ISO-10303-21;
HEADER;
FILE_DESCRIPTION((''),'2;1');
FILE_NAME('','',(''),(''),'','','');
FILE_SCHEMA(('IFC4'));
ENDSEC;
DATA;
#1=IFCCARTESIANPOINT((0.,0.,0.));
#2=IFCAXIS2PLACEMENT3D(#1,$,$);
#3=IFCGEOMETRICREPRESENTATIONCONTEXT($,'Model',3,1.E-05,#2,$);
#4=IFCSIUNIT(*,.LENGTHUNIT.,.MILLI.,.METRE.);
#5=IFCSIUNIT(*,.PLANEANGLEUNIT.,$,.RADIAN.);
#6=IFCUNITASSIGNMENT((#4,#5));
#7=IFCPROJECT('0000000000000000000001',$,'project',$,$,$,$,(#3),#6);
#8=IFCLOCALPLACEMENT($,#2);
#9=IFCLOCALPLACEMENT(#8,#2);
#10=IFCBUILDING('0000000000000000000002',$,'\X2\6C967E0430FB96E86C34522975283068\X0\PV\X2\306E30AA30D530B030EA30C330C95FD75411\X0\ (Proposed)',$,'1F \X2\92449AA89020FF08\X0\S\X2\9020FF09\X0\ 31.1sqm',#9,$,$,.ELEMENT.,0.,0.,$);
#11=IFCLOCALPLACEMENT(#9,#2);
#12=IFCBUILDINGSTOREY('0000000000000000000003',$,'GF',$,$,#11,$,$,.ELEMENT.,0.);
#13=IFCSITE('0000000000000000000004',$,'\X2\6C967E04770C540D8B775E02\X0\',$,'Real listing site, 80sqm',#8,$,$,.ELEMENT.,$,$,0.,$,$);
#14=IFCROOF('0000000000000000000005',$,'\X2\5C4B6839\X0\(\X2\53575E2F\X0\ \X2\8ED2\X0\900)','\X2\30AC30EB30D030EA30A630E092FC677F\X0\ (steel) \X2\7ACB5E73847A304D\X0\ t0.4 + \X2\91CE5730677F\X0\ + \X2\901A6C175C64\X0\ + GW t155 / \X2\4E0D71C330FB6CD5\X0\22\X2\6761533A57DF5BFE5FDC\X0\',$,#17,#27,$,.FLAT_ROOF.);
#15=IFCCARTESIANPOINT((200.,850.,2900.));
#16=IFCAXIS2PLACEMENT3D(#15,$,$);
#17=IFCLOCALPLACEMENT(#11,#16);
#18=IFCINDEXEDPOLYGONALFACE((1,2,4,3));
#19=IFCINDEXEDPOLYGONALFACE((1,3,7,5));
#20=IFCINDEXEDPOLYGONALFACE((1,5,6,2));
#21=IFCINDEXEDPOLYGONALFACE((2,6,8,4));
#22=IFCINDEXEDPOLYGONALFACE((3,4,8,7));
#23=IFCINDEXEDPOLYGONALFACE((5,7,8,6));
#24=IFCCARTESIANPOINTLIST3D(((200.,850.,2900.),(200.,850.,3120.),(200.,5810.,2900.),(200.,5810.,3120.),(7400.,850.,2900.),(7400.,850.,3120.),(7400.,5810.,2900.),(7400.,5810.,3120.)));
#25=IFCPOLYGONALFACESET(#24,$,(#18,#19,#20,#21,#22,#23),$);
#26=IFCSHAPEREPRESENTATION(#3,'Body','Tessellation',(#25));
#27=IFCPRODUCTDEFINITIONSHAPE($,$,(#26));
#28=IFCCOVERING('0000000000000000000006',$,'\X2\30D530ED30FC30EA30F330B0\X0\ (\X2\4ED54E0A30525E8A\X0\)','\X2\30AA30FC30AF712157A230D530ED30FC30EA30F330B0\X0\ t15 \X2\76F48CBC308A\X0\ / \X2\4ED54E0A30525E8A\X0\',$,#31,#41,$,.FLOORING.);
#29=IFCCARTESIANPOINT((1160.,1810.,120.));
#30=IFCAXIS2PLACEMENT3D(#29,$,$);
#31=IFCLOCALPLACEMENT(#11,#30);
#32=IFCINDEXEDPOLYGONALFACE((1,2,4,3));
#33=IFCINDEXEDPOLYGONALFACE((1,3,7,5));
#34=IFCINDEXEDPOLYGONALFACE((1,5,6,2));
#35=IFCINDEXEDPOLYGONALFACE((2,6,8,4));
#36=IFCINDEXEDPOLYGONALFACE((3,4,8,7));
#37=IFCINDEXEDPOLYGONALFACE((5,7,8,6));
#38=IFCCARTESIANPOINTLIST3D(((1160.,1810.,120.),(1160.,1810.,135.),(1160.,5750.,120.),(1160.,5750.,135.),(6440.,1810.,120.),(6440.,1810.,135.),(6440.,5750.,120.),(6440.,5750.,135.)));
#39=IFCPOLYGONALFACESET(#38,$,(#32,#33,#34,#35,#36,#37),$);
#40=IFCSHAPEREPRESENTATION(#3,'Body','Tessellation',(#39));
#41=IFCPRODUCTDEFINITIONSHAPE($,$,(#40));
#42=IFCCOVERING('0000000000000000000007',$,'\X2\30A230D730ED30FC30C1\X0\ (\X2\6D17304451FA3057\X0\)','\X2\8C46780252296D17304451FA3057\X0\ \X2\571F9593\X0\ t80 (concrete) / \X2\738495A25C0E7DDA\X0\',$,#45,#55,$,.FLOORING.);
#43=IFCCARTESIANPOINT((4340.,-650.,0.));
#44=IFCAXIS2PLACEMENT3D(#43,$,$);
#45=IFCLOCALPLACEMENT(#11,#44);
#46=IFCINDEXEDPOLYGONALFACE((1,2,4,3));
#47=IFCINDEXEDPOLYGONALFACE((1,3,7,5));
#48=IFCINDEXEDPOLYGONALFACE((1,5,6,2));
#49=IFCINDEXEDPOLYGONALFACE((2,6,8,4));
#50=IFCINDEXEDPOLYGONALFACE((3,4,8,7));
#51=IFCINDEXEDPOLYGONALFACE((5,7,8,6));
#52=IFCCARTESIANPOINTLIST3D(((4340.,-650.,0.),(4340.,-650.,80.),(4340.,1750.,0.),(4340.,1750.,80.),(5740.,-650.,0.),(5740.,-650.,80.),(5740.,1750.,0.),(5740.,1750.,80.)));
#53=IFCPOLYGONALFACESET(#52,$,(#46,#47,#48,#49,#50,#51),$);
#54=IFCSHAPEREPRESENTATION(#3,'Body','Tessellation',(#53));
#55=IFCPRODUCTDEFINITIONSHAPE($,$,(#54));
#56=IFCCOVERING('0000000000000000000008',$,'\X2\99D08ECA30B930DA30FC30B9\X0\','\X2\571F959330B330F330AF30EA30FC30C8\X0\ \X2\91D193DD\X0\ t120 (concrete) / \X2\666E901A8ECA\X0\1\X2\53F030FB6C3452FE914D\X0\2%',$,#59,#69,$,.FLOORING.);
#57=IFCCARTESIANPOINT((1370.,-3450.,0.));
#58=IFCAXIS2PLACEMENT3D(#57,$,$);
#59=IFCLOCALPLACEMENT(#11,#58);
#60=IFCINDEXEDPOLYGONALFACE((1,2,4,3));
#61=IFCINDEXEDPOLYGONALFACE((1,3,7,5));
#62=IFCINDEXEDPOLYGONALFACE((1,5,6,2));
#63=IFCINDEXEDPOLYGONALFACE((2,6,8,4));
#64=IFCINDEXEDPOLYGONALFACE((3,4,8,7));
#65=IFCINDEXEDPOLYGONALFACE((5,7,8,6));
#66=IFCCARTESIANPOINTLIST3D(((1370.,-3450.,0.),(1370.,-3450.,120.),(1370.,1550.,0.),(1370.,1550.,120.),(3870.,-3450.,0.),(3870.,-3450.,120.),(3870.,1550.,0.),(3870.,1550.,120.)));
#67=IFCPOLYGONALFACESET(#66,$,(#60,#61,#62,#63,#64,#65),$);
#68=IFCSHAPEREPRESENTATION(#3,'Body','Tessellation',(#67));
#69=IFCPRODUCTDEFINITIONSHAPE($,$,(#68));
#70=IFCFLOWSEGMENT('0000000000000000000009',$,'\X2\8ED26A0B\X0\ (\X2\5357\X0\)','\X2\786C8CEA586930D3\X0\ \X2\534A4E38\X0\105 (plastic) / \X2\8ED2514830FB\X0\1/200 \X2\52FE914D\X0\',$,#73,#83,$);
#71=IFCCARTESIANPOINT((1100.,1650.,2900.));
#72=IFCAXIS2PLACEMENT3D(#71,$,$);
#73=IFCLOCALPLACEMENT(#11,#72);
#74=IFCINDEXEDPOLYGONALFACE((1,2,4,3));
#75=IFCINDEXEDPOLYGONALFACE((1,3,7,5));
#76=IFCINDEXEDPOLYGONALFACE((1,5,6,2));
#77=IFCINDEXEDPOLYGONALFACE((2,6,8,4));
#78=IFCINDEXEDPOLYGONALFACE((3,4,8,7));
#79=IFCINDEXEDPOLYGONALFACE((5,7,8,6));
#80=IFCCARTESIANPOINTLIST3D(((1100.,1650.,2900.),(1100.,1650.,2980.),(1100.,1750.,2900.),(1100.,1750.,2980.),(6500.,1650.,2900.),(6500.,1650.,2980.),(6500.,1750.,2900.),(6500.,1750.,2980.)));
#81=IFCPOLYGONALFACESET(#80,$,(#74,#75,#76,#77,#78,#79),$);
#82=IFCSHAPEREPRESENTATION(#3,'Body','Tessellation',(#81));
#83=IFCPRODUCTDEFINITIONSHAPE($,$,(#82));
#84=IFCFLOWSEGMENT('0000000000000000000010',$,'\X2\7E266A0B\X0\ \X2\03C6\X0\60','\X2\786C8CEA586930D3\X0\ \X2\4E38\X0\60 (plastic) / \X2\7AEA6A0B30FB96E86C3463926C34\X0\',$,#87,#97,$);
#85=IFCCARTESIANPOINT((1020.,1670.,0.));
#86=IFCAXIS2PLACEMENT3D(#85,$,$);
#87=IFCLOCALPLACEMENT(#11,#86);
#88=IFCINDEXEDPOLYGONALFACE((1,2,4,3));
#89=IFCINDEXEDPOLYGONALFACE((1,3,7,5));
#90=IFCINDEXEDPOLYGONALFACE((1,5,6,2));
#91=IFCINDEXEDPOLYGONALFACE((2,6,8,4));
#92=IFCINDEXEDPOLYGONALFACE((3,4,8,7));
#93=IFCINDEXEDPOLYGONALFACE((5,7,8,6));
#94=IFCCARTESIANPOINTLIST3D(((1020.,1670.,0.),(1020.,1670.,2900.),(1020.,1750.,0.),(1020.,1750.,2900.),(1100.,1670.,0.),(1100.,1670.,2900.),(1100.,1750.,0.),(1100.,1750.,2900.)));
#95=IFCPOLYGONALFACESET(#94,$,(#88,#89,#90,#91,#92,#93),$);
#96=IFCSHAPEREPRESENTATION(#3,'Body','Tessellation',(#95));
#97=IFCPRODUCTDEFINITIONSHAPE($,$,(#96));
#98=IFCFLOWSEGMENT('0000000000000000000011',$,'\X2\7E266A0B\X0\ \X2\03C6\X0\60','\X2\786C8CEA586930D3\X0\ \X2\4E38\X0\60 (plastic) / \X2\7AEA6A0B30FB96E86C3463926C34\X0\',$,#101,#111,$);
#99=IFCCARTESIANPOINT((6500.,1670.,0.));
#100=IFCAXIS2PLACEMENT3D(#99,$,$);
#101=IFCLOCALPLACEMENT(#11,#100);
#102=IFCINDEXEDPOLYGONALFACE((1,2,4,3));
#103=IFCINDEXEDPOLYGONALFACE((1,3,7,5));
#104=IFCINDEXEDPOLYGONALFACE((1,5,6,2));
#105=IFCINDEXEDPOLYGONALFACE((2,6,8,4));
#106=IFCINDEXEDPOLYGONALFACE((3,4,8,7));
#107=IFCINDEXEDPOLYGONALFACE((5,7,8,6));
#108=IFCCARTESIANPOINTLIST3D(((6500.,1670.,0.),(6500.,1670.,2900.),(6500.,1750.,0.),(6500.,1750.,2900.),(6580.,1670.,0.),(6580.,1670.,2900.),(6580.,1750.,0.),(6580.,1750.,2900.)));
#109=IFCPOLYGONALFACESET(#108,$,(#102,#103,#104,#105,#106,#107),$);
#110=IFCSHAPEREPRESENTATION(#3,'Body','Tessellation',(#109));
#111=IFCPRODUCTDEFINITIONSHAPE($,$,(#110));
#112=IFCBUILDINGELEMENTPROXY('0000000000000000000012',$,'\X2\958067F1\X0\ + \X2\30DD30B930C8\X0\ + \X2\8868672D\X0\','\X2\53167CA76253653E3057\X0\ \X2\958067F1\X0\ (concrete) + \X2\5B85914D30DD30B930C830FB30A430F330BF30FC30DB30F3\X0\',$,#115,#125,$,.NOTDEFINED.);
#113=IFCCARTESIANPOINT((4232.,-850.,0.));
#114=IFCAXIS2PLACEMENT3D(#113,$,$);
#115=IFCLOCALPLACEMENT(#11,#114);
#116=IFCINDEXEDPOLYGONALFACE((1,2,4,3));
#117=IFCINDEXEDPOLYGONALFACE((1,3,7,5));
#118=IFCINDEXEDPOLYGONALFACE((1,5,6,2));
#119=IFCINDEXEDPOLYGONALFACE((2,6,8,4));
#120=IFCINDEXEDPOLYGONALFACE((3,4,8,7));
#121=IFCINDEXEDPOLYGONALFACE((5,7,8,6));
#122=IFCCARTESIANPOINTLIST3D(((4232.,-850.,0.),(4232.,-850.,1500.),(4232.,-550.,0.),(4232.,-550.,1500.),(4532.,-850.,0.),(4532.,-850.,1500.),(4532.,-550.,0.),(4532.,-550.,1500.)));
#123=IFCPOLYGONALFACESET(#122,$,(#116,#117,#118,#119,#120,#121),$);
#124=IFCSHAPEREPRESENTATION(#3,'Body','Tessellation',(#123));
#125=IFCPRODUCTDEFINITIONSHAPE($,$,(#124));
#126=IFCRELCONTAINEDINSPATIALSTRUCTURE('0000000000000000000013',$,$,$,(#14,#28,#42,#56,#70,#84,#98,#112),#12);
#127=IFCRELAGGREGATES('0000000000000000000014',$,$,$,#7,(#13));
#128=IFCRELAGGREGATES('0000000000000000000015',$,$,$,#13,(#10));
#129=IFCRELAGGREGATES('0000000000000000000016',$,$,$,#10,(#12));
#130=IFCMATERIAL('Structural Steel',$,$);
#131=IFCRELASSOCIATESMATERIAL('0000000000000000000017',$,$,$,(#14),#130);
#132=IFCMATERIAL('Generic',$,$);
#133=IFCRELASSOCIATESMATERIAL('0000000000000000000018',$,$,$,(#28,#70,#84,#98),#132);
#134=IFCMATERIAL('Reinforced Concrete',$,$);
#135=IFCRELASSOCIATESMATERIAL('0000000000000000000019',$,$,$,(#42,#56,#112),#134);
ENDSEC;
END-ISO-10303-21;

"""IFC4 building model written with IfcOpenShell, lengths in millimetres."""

from ifc_helpers import new_model, si_unit, frame, frame_2d, origin, place, context, project, spatial, rectangle, extrude, material, element, save


model = new_model("IFC4")

# Units and contexts
model_context = context("Model", 3, precision=1e-05, world=origin())
ifc_project = project(units=[si_unit("LENGTHUNIT", "METRE", prefix="MILLI"), si_unit("PLANEANGLEUNIT", "RADIAN")], contexts=[model_context])

# Site, building, storey
site_placement = place(None, origin())
site = spatial("IfcSite", under=ifc_project, at=site_placement, Name="沖縄県名護市", ObjectType="Real listing site, 80sqm", CompositionType="ELEMENT", RefElevation=0.0)
building_placement = place(site_placement, origin())
building = spatial("IfcBuilding", under=site, at=building_placement, Name="沖縄・雨水利用とPVのオフグリッド志向 (Proposed)", ObjectType="1F 鉄骨造（S造） 31.1sqm", CompositionType="ELEMENT", ElevationOfRefHeight=0.0, ElevationOfTerrain=0.0)
storey_placement = place(building_placement, origin())
storey = spatial("IfcBuildingStorey", under=building, at=storey_placement, Name="GF", CompositionType="ELEMENT", Elevation=0.0)

# Shared definitions
ifc_material_1 = material(Name="Reinforced Concrete")

# Roof
ifc_material_2 = material(Name="Structural Steel")
roof_placement = place(storey_placement, frame((200.0, 850.0, 2900.0)))
element("IfcRoof", 1, at=roof_placement, inside=storey, material=ifc_material_2, Name="屋根(南帯 軒900)", Description="ガルバリウム鋼板 (steel) 立平葺き t0.4 + 野地板 + 通気層 + GW t155 / 不燃・法22条区域対応", PredefinedType="FLAT_ROOF", context=model_context, shape_type="SweptSolid", body=[
    extrude(rectangle(XDim=7200.0, YDim=4960.0, at=frame_2d((3600.0, 2480.0))), frame((200.0, 850.0, 2900.0)), (0.0, 0.0, 1.0), 220.0),
])

# Coverings
ifc_material_3 = material(Name="Generic")
covering_1_placement = place(storey_placement, frame((1160.0, 1810.0, 120.0)))
element("IfcCovering", 2, at=covering_1_placement, inside=storey, material=ifc_material_3, Name="フローリング (仕上げ床)", Description="オーク無垢フローリング t15 直貼り / 仕上げ床", PredefinedType="FLOORING", context=model_context, shape_type="SweptSolid", body=[
    extrude(rectangle(XDim=5280.0, YDim=3940.0, at=frame_2d((2640.0, 1970.0))), frame((1160.0, 1810.0, 120.0)), (0.0, 0.0, 1.0), 15.0),
])
covering_2_placement = place(storey_placement, frame((4340.0, -650.0, 0.0)))
element("IfcCovering", 3, at=covering_2_placement, inside=storey, material=ifc_material_1, Name="アプローチ (洗い出し)", Description="豆砂利洗い出し 土間 t80 (concrete) / 玄関導線", PredefinedType="FLOORING", context=model_context, shape_type="SweptSolid", body=[
    extrude(rectangle(XDim=1400.0, YDim=2400.0, at=frame_2d((700.0, 1200.0))), frame((4340.0, -650.0, 0.0)), (0.0, 0.0, 1.0), 80.0),
])
covering_3_placement = place(storey_placement, frame((1370.0, -3450.0, 0.0)))
element("IfcCovering", 4, at=covering_3_placement, inside=storey, material=ifc_material_1, Name="駐車スペース", Description="土間コンクリート 金鏝 t120 (concrete) / 普通車1台・水勾配2%", PredefinedType="FLOORING", context=model_context, shape_type="SweptSolid", body=[
    extrude(rectangle(XDim=2500.0, YDim=5000.0, at=frame_2d((1250.0, 2500.0))), frame((1370.0, -3450.0, 0.0)), (0.0, 0.0, 1.0), 120.0),
])

# Flow segments
flow_segment_1_placement = place(storey_placement, frame((1100.0, 1650.0, 2900.0)))
element("IfcFlowSegment", 5, at=flow_segment_1_placement, inside=storey, material=ifc_material_3, Name="軒樋 (南)", Description="硬質塩ビ 半丸105 (plastic) / 軒先・1/200 勾配", context=model_context, shape_type="SweptSolid", body=[
    extrude(rectangle(XDim=5400.0, YDim=100.0, at=frame_2d((2700.0, 50.0))), frame((1100.0, 1650.0, 2900.0)), (0.0, 0.0, 1.0), 80.0),
])
flow_segment_2_placement = place(storey_placement, frame((1020.0, 1670.0, 0.0)))
element("IfcFlowSegment", 6, at=flow_segment_2_placement, inside=storey, material=ifc_material_3, Name="縦樋 φ60", Description="硬質塩ビ 丸60 (plastic) / 竪樋・雨水排水", context=model_context, shape_type="SweptSolid", body=[
    extrude(rectangle(XDim=80.0, YDim=80.0, at=frame_2d((40.0, 40.0))), frame((1020.0, 1670.0, 0.0)), (0.0, 0.0, 1.0), 2900.0),
])
flow_segment_3_placement = place(storey_placement, frame((6500.0, 1670.0, 0.0)))
element("IfcFlowSegment", 7, at=flow_segment_3_placement, inside=storey, material=ifc_material_3, Name="縦樋 φ60", Description="硬質塩ビ 丸60 (plastic) / 竪樋・雨水排水", context=model_context, shape_type="SweptSolid", body=[
    extrude(rectangle(XDim=80.0, YDim=80.0, at=frame_2d((40.0, 40.0))), frame((6500.0, 1670.0, 0.0)), (0.0, 0.0, 1.0), 2900.0),
])

# Building element proxy
proxy_placement = place(storey_placement, frame((4232.0, -850.0, 0.0)))
element("IfcBuildingElementProxy", 8, at=proxy_placement, inside=storey, material=ifc_material_1, Name="門柱 + ポスト + 表札", Description="化粧打放し 門柱 (concrete) + 宅配ポスト・インターホン", PredefinedType="NOTDEFINED", context=model_context, shape_type="SweptSolid", body=[
    extrude(rectangle(XDim=300.0, YDim=300.0, at=frame_2d((150.0, 150.0))), frame((4232.0, -850.0, 0.0)), (0.0, 0.0, 1.0), 1500.0),
])

save(model, "model.ifc")
